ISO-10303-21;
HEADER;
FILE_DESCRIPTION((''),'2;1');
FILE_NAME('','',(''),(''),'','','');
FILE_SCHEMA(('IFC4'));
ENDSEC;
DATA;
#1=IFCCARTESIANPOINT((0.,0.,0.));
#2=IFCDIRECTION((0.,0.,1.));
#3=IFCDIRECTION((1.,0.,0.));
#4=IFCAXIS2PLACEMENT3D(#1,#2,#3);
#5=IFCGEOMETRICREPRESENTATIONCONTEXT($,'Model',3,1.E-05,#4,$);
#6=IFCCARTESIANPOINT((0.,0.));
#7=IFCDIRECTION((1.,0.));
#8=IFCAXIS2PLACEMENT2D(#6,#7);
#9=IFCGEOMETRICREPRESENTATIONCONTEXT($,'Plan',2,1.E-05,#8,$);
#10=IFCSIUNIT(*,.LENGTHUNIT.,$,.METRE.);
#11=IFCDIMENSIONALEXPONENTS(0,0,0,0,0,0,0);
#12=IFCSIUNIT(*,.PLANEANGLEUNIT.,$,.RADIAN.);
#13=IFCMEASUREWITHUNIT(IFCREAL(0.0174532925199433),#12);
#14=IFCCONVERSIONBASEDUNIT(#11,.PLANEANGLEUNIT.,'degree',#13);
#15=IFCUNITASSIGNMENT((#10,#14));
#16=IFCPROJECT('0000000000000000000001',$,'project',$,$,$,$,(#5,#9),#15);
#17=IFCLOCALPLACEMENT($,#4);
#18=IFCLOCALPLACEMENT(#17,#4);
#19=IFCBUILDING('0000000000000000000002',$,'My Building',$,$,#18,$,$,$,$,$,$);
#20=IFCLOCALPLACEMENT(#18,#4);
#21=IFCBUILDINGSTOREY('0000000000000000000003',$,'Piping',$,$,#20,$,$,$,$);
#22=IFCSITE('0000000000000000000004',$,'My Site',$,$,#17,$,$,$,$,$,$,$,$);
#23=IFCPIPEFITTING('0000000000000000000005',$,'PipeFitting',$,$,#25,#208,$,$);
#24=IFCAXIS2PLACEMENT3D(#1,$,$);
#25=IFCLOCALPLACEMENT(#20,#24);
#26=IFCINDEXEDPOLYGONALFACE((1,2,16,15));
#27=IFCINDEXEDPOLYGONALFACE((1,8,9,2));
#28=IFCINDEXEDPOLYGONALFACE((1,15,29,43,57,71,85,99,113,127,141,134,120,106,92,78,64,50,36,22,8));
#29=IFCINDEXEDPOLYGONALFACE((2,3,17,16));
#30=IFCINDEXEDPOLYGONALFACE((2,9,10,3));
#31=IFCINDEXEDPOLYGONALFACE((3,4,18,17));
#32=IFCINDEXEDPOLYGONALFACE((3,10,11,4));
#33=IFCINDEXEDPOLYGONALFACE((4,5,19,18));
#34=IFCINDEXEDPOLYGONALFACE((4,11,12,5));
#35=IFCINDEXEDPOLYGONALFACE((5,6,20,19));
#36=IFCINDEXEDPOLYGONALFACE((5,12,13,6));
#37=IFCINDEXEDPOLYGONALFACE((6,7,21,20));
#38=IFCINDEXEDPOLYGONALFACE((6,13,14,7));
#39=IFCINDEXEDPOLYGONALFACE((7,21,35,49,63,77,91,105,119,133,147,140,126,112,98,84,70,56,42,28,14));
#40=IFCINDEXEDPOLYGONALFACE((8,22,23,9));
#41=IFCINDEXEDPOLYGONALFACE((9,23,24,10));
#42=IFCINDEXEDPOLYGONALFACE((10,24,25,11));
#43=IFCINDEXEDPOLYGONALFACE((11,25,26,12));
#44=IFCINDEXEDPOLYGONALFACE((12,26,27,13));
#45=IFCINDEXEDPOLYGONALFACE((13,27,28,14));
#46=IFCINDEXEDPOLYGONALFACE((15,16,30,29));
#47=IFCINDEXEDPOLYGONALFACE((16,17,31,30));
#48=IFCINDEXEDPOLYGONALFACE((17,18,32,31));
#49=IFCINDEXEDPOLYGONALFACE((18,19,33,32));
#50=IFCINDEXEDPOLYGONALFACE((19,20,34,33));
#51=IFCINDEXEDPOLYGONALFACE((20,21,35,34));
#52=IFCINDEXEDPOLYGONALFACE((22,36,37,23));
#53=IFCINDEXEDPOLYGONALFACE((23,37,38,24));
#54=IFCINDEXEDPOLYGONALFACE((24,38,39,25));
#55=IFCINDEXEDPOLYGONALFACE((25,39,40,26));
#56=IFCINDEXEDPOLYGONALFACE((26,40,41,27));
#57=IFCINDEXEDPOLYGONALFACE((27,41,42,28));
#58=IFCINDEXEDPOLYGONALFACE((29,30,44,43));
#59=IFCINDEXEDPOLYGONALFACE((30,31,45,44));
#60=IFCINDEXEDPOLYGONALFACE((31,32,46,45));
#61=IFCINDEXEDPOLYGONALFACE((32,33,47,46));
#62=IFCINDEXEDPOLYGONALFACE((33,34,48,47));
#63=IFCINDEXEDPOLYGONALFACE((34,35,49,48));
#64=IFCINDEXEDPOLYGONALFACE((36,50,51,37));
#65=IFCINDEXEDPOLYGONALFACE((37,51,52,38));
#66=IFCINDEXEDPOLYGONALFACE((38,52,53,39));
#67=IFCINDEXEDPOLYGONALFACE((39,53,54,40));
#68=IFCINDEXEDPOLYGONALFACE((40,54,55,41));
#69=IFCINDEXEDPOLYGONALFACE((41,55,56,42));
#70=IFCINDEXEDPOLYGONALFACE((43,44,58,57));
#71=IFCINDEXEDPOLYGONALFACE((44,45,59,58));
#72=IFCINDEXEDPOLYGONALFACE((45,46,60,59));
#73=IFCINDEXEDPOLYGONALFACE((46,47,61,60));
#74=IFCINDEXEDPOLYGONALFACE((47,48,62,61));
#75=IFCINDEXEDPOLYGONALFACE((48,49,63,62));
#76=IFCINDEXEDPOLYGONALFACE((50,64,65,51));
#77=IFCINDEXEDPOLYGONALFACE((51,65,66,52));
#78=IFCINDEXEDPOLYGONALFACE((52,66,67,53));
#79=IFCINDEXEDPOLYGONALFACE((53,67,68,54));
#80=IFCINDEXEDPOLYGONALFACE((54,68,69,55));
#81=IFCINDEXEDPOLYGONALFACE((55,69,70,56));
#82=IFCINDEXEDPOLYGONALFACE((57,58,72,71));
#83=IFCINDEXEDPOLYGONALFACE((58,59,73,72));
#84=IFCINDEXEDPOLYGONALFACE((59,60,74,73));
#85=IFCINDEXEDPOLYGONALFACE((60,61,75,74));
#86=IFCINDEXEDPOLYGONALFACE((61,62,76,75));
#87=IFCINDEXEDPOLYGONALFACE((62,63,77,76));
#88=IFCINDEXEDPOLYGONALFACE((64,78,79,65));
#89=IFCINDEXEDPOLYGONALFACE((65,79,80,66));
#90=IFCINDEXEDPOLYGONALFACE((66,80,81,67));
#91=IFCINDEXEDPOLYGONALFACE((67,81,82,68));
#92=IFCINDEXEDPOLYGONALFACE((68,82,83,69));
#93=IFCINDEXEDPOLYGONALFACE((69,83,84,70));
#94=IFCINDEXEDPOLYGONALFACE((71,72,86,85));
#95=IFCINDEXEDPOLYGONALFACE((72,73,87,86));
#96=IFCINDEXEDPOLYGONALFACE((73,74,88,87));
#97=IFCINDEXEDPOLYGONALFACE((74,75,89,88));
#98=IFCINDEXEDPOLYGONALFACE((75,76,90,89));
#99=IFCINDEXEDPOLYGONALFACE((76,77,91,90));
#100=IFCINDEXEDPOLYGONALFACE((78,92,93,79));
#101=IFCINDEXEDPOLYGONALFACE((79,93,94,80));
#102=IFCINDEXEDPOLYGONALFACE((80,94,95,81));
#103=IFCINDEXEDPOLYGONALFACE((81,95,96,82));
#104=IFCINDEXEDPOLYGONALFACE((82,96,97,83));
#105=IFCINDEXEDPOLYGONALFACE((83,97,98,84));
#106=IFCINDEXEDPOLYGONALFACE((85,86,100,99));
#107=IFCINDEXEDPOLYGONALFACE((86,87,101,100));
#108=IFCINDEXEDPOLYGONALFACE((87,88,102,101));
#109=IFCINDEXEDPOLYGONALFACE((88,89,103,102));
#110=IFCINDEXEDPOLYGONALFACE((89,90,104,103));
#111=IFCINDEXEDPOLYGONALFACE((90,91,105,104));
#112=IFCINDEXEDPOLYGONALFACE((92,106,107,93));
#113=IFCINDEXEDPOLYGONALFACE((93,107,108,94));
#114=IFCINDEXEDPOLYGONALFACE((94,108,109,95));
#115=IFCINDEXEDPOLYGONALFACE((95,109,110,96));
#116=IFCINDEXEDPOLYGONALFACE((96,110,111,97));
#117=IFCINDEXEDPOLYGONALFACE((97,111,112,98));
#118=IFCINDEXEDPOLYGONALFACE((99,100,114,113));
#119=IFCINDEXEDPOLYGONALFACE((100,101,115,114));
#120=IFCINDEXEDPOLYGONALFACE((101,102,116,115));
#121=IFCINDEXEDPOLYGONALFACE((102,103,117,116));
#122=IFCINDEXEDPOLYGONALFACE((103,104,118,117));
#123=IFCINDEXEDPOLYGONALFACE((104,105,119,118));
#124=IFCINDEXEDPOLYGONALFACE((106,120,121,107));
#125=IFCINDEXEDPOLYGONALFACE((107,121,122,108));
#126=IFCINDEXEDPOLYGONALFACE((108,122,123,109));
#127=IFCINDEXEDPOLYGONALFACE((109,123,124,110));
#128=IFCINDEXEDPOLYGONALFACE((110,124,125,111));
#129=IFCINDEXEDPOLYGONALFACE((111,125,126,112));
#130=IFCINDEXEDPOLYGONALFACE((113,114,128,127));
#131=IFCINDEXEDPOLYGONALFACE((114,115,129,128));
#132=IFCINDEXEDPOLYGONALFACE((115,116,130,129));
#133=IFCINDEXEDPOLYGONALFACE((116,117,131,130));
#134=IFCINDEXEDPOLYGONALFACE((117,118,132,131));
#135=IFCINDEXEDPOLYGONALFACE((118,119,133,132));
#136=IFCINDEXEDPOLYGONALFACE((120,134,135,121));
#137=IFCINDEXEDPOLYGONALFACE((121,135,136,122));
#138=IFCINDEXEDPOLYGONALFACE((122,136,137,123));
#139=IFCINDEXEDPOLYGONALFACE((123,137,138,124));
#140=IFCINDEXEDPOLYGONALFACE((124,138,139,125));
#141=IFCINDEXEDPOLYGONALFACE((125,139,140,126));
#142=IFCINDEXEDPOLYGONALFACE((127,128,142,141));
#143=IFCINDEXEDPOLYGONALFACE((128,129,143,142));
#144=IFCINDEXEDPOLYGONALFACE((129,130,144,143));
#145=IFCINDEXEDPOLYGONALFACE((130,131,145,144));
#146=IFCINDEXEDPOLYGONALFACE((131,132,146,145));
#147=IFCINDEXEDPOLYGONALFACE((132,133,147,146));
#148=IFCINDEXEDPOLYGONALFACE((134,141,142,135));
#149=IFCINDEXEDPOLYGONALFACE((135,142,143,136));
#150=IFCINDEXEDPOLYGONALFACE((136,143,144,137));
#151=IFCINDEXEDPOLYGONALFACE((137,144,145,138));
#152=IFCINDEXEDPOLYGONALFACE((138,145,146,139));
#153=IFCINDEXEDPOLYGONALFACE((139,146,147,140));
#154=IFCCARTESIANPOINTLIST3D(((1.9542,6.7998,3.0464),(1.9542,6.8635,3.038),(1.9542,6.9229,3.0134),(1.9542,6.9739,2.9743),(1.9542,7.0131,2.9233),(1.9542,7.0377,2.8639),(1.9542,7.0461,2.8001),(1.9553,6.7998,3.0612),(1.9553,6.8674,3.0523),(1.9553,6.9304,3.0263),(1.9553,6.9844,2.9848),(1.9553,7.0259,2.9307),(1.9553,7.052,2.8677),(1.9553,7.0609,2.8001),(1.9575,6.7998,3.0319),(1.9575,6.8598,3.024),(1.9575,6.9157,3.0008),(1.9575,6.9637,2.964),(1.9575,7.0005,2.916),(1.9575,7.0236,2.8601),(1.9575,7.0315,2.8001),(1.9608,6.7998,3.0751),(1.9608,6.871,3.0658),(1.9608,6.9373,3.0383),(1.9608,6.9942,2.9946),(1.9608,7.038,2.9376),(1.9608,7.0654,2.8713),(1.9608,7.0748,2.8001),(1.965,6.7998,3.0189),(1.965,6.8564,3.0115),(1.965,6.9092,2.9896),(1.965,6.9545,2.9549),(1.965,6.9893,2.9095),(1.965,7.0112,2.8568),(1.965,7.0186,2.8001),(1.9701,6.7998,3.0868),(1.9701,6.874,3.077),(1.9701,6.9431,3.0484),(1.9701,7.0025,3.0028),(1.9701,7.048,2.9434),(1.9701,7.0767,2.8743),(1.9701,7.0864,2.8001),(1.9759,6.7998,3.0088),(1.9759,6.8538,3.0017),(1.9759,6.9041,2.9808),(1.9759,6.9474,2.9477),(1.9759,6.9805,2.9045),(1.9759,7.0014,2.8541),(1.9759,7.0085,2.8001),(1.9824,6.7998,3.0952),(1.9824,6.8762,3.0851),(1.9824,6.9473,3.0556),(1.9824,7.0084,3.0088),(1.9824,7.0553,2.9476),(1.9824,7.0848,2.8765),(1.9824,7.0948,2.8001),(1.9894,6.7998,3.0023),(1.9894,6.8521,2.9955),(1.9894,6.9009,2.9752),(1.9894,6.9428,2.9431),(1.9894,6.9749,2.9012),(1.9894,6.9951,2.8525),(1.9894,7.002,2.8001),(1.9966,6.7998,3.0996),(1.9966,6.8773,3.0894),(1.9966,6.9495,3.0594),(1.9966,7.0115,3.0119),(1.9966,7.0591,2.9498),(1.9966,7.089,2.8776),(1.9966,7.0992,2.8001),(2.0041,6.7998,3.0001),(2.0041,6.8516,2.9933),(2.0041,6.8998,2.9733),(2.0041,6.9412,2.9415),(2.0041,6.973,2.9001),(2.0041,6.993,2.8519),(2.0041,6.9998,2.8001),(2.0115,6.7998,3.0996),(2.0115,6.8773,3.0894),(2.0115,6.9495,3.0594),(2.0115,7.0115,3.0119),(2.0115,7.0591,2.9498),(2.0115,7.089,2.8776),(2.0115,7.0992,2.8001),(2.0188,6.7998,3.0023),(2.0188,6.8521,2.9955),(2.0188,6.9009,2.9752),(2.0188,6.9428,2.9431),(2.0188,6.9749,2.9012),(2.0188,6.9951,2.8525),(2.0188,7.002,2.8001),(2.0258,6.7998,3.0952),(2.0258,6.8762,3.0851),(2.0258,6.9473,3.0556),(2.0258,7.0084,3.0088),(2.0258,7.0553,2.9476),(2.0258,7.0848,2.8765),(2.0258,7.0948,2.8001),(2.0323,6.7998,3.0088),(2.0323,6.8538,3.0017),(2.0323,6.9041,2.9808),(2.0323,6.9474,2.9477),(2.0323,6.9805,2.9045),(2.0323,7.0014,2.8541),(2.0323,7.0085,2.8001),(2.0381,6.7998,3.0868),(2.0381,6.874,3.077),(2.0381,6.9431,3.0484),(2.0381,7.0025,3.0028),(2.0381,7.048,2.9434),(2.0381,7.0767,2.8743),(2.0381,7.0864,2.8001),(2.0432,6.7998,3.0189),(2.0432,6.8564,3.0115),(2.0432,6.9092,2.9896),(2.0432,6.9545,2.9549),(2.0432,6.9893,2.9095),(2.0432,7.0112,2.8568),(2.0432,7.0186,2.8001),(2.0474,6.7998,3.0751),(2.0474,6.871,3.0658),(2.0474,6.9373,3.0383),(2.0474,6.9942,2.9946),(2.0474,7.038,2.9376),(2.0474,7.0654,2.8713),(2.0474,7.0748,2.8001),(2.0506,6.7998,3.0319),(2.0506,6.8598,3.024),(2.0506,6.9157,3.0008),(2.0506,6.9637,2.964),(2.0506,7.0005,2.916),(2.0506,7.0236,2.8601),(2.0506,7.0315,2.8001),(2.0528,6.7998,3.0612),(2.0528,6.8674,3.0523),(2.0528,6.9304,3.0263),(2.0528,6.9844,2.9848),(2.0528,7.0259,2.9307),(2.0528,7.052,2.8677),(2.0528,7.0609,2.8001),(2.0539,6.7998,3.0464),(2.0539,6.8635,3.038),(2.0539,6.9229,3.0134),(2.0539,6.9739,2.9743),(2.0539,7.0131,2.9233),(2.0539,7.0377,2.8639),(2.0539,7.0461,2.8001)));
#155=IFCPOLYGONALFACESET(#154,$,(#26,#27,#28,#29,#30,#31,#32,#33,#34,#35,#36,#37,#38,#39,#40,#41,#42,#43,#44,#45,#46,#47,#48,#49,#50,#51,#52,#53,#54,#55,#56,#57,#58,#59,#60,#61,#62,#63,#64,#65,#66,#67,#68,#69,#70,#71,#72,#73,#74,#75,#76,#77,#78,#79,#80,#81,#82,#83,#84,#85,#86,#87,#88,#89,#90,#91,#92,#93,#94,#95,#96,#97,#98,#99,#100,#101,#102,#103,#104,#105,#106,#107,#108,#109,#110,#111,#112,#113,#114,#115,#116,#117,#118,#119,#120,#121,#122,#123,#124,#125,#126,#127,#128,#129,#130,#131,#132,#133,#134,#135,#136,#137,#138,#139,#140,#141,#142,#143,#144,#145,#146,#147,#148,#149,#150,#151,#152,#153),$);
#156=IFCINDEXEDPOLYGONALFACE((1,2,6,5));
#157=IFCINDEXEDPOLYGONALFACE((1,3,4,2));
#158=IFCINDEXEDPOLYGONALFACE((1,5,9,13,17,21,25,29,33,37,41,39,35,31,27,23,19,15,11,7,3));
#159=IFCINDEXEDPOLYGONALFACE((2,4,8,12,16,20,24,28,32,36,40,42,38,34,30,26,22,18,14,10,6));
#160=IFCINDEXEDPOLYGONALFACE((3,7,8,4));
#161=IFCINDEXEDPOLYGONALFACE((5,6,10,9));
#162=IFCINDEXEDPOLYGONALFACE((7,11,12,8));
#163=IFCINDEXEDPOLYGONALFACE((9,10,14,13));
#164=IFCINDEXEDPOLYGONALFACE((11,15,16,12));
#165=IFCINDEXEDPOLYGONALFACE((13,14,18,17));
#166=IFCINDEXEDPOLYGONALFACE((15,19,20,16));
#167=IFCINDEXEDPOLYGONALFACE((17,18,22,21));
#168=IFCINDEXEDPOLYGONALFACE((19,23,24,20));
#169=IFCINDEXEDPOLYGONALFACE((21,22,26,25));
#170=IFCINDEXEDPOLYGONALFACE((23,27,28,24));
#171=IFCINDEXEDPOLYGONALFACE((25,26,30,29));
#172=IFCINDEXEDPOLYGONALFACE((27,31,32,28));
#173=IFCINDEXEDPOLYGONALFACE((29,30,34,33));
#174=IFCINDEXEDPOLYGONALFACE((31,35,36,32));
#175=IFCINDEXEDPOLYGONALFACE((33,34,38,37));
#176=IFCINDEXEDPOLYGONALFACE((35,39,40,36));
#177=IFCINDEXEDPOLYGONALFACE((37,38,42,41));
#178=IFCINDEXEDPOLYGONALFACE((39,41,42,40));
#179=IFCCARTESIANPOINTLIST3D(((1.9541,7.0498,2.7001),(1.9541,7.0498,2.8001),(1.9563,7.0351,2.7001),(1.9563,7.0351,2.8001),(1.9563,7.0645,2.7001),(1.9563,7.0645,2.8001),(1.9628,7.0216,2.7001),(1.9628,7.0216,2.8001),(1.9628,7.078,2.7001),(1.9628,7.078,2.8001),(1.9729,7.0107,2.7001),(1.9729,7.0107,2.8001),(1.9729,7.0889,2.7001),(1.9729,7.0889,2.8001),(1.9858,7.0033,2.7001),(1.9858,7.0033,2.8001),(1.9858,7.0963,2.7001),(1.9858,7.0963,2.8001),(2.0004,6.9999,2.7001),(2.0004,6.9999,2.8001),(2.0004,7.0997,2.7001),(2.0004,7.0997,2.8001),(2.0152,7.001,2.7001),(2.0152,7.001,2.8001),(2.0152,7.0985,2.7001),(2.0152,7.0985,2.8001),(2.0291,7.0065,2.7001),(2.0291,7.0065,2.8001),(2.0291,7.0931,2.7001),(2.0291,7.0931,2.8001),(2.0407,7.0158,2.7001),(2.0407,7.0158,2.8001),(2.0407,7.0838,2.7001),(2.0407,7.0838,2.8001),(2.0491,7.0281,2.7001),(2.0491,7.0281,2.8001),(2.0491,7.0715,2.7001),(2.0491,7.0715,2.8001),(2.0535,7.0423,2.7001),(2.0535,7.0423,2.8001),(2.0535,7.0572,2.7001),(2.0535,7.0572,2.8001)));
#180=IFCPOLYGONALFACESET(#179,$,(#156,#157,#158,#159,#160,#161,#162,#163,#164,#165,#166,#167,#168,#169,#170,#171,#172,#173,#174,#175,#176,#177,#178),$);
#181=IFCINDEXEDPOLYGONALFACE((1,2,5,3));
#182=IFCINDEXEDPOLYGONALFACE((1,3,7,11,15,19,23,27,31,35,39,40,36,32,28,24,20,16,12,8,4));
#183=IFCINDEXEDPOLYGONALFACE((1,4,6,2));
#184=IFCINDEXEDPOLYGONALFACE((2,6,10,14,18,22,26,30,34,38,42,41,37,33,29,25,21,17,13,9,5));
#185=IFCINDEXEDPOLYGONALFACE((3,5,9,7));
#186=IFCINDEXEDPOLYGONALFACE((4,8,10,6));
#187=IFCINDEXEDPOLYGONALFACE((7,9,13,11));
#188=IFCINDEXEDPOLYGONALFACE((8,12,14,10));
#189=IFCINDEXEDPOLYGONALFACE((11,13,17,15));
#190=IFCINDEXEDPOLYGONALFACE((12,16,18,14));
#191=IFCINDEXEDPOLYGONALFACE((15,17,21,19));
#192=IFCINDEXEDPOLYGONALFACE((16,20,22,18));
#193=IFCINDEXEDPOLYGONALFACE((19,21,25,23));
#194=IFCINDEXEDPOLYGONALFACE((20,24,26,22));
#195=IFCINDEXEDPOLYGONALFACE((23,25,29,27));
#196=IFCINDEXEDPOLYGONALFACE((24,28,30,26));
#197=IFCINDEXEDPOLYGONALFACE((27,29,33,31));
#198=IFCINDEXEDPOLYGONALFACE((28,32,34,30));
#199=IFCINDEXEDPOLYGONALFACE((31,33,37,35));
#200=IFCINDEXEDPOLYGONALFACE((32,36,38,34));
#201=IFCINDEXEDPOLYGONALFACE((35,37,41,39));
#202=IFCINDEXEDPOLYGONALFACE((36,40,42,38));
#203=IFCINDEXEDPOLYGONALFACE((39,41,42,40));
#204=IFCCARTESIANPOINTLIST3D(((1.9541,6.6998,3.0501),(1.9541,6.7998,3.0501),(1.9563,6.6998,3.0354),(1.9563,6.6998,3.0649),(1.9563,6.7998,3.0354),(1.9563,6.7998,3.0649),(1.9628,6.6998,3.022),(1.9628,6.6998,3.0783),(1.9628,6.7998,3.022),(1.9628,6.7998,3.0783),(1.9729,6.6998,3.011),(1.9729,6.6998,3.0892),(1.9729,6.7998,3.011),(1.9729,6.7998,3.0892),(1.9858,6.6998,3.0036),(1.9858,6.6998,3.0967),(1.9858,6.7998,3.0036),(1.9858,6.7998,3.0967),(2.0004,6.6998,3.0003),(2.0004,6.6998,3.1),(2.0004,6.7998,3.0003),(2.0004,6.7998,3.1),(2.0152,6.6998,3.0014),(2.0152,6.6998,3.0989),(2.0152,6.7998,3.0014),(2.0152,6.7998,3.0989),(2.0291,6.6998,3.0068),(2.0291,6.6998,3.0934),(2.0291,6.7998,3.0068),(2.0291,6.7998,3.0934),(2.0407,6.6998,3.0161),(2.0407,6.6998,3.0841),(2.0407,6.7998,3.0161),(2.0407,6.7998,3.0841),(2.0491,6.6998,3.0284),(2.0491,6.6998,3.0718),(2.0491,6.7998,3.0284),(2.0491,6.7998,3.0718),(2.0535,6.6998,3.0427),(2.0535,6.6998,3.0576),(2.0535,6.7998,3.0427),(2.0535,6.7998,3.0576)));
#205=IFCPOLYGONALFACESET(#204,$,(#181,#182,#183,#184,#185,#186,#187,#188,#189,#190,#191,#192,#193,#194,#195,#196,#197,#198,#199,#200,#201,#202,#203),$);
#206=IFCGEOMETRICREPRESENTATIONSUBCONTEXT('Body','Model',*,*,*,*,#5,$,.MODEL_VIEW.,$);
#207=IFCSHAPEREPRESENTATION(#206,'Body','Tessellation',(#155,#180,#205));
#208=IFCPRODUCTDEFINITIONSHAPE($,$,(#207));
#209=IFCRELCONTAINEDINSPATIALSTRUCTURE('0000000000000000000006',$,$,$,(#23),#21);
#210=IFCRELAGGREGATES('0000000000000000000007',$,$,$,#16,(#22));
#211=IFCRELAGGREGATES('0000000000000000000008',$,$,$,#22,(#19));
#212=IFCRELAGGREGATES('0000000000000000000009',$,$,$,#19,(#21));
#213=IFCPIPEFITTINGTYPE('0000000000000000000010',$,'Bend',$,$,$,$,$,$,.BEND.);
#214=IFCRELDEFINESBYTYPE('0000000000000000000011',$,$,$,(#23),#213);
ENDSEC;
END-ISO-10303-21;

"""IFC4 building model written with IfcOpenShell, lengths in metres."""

from ifc_helpers import new_model, entity, si_unit, converted_unit, frame, origin_with_axes, origin_2d_with_axis, place, context, subcontext, project, spatial, circle, extrude, source, transform, mapped, type_object, type_shapes, element, save


model = new_model("IFC4")

# Units and contexts
model_context = context("Model", 3, precision=1e-05, world=origin_with_axes())
plan_context = context("Plan", 2, precision=1e-05, world=origin_2d_with_axis())
body_context = subcontext(model_context, "Body", "Model", "MODEL_VIEW")
ifc_project = project(units=[si_unit("LENGTHUNIT", "METRE"), converted_unit("PLANEANGLEUNIT", "degree", entity("IfcReal", 0.0174532925199433), si_unit("PLANEANGLEUNIT", "RADIAN"), dimensions=[0, 0, 0, 0, 0, 0, 0])], contexts=[model_context, plan_context])

# Site, building, storey
site_placement = place(None, origin_with_axes())
site = spatial("IfcSite", under=ifc_project, at=site_placement, Name="My Site")
building_placement = place(site_placement, origin_with_axes())
building = spatial("IfcBuilding", under=site, at=building_placement, Name="My Building")
storey_placement = place(building_placement, origin_with_axes())
storey = spatial("IfcBuildingStorey", under=building, at=storey_placement, Name="Piping")

# Pipe fitting
pipe_fitting_type_1 = type_object("IfcPipeFittingType", Name="Bend", PredefinedType="BEND")
shared_shape = source(origin_with_axes(), body_context, "Body", "SolidModel", [
    entity("IfcSweptDiskSolid", entity("IfcIndexedPolyCurve", entity("IfcCartesianPointList3D", [[0.0, 0.0, -0.1], [0.0, -0.0732, -0.2768], [0.0, -0.25, -0.35]]), [entity("IfcArcIndex", [1, 2, 3])]), 0.05),
    extrude(circle(Radius=0.05), origin_with_axes(), (0.0, 0.0, -1.0), 0.1),
    extrude(circle(Radius=0.05), frame((0.0, -0.25, -0.35), z_axis=(0.0, -1.0, 0.0), x_axis=(1.0, 0.0, 0.0)), (0.0, 0.0, 1.0), 0.1),
])
type_shapes(pipe_fitting_type_1, [shared_shape])
for number, where, z_axis, x_axis, name in (
    (1, (2.0041, 7.0498, 2.7001), (0.0, 0.0, -1.0), (-1.0, 0.0, 0.0), "PipeFitting"),
):
    element("IfcPipeFitting", number, at=place(storey_placement, frame(where, z_axis=z_axis, x_axis=x_axis)), inside=storey, type_object=pipe_fitting_type_1, Name=name, context=body_context, shape_type="MappedRepresentation", body=[
        mapped(shared_shape, transform((0.0, 0.0, 0.0), x_axis=(1.0, 0.0, 0.0), y_axis=(0.0, 1.0, 0.0), z_axis=(0.0, 0.0, 1.0), scale=1.0)),
    ])

save(model, "model.ifc")
